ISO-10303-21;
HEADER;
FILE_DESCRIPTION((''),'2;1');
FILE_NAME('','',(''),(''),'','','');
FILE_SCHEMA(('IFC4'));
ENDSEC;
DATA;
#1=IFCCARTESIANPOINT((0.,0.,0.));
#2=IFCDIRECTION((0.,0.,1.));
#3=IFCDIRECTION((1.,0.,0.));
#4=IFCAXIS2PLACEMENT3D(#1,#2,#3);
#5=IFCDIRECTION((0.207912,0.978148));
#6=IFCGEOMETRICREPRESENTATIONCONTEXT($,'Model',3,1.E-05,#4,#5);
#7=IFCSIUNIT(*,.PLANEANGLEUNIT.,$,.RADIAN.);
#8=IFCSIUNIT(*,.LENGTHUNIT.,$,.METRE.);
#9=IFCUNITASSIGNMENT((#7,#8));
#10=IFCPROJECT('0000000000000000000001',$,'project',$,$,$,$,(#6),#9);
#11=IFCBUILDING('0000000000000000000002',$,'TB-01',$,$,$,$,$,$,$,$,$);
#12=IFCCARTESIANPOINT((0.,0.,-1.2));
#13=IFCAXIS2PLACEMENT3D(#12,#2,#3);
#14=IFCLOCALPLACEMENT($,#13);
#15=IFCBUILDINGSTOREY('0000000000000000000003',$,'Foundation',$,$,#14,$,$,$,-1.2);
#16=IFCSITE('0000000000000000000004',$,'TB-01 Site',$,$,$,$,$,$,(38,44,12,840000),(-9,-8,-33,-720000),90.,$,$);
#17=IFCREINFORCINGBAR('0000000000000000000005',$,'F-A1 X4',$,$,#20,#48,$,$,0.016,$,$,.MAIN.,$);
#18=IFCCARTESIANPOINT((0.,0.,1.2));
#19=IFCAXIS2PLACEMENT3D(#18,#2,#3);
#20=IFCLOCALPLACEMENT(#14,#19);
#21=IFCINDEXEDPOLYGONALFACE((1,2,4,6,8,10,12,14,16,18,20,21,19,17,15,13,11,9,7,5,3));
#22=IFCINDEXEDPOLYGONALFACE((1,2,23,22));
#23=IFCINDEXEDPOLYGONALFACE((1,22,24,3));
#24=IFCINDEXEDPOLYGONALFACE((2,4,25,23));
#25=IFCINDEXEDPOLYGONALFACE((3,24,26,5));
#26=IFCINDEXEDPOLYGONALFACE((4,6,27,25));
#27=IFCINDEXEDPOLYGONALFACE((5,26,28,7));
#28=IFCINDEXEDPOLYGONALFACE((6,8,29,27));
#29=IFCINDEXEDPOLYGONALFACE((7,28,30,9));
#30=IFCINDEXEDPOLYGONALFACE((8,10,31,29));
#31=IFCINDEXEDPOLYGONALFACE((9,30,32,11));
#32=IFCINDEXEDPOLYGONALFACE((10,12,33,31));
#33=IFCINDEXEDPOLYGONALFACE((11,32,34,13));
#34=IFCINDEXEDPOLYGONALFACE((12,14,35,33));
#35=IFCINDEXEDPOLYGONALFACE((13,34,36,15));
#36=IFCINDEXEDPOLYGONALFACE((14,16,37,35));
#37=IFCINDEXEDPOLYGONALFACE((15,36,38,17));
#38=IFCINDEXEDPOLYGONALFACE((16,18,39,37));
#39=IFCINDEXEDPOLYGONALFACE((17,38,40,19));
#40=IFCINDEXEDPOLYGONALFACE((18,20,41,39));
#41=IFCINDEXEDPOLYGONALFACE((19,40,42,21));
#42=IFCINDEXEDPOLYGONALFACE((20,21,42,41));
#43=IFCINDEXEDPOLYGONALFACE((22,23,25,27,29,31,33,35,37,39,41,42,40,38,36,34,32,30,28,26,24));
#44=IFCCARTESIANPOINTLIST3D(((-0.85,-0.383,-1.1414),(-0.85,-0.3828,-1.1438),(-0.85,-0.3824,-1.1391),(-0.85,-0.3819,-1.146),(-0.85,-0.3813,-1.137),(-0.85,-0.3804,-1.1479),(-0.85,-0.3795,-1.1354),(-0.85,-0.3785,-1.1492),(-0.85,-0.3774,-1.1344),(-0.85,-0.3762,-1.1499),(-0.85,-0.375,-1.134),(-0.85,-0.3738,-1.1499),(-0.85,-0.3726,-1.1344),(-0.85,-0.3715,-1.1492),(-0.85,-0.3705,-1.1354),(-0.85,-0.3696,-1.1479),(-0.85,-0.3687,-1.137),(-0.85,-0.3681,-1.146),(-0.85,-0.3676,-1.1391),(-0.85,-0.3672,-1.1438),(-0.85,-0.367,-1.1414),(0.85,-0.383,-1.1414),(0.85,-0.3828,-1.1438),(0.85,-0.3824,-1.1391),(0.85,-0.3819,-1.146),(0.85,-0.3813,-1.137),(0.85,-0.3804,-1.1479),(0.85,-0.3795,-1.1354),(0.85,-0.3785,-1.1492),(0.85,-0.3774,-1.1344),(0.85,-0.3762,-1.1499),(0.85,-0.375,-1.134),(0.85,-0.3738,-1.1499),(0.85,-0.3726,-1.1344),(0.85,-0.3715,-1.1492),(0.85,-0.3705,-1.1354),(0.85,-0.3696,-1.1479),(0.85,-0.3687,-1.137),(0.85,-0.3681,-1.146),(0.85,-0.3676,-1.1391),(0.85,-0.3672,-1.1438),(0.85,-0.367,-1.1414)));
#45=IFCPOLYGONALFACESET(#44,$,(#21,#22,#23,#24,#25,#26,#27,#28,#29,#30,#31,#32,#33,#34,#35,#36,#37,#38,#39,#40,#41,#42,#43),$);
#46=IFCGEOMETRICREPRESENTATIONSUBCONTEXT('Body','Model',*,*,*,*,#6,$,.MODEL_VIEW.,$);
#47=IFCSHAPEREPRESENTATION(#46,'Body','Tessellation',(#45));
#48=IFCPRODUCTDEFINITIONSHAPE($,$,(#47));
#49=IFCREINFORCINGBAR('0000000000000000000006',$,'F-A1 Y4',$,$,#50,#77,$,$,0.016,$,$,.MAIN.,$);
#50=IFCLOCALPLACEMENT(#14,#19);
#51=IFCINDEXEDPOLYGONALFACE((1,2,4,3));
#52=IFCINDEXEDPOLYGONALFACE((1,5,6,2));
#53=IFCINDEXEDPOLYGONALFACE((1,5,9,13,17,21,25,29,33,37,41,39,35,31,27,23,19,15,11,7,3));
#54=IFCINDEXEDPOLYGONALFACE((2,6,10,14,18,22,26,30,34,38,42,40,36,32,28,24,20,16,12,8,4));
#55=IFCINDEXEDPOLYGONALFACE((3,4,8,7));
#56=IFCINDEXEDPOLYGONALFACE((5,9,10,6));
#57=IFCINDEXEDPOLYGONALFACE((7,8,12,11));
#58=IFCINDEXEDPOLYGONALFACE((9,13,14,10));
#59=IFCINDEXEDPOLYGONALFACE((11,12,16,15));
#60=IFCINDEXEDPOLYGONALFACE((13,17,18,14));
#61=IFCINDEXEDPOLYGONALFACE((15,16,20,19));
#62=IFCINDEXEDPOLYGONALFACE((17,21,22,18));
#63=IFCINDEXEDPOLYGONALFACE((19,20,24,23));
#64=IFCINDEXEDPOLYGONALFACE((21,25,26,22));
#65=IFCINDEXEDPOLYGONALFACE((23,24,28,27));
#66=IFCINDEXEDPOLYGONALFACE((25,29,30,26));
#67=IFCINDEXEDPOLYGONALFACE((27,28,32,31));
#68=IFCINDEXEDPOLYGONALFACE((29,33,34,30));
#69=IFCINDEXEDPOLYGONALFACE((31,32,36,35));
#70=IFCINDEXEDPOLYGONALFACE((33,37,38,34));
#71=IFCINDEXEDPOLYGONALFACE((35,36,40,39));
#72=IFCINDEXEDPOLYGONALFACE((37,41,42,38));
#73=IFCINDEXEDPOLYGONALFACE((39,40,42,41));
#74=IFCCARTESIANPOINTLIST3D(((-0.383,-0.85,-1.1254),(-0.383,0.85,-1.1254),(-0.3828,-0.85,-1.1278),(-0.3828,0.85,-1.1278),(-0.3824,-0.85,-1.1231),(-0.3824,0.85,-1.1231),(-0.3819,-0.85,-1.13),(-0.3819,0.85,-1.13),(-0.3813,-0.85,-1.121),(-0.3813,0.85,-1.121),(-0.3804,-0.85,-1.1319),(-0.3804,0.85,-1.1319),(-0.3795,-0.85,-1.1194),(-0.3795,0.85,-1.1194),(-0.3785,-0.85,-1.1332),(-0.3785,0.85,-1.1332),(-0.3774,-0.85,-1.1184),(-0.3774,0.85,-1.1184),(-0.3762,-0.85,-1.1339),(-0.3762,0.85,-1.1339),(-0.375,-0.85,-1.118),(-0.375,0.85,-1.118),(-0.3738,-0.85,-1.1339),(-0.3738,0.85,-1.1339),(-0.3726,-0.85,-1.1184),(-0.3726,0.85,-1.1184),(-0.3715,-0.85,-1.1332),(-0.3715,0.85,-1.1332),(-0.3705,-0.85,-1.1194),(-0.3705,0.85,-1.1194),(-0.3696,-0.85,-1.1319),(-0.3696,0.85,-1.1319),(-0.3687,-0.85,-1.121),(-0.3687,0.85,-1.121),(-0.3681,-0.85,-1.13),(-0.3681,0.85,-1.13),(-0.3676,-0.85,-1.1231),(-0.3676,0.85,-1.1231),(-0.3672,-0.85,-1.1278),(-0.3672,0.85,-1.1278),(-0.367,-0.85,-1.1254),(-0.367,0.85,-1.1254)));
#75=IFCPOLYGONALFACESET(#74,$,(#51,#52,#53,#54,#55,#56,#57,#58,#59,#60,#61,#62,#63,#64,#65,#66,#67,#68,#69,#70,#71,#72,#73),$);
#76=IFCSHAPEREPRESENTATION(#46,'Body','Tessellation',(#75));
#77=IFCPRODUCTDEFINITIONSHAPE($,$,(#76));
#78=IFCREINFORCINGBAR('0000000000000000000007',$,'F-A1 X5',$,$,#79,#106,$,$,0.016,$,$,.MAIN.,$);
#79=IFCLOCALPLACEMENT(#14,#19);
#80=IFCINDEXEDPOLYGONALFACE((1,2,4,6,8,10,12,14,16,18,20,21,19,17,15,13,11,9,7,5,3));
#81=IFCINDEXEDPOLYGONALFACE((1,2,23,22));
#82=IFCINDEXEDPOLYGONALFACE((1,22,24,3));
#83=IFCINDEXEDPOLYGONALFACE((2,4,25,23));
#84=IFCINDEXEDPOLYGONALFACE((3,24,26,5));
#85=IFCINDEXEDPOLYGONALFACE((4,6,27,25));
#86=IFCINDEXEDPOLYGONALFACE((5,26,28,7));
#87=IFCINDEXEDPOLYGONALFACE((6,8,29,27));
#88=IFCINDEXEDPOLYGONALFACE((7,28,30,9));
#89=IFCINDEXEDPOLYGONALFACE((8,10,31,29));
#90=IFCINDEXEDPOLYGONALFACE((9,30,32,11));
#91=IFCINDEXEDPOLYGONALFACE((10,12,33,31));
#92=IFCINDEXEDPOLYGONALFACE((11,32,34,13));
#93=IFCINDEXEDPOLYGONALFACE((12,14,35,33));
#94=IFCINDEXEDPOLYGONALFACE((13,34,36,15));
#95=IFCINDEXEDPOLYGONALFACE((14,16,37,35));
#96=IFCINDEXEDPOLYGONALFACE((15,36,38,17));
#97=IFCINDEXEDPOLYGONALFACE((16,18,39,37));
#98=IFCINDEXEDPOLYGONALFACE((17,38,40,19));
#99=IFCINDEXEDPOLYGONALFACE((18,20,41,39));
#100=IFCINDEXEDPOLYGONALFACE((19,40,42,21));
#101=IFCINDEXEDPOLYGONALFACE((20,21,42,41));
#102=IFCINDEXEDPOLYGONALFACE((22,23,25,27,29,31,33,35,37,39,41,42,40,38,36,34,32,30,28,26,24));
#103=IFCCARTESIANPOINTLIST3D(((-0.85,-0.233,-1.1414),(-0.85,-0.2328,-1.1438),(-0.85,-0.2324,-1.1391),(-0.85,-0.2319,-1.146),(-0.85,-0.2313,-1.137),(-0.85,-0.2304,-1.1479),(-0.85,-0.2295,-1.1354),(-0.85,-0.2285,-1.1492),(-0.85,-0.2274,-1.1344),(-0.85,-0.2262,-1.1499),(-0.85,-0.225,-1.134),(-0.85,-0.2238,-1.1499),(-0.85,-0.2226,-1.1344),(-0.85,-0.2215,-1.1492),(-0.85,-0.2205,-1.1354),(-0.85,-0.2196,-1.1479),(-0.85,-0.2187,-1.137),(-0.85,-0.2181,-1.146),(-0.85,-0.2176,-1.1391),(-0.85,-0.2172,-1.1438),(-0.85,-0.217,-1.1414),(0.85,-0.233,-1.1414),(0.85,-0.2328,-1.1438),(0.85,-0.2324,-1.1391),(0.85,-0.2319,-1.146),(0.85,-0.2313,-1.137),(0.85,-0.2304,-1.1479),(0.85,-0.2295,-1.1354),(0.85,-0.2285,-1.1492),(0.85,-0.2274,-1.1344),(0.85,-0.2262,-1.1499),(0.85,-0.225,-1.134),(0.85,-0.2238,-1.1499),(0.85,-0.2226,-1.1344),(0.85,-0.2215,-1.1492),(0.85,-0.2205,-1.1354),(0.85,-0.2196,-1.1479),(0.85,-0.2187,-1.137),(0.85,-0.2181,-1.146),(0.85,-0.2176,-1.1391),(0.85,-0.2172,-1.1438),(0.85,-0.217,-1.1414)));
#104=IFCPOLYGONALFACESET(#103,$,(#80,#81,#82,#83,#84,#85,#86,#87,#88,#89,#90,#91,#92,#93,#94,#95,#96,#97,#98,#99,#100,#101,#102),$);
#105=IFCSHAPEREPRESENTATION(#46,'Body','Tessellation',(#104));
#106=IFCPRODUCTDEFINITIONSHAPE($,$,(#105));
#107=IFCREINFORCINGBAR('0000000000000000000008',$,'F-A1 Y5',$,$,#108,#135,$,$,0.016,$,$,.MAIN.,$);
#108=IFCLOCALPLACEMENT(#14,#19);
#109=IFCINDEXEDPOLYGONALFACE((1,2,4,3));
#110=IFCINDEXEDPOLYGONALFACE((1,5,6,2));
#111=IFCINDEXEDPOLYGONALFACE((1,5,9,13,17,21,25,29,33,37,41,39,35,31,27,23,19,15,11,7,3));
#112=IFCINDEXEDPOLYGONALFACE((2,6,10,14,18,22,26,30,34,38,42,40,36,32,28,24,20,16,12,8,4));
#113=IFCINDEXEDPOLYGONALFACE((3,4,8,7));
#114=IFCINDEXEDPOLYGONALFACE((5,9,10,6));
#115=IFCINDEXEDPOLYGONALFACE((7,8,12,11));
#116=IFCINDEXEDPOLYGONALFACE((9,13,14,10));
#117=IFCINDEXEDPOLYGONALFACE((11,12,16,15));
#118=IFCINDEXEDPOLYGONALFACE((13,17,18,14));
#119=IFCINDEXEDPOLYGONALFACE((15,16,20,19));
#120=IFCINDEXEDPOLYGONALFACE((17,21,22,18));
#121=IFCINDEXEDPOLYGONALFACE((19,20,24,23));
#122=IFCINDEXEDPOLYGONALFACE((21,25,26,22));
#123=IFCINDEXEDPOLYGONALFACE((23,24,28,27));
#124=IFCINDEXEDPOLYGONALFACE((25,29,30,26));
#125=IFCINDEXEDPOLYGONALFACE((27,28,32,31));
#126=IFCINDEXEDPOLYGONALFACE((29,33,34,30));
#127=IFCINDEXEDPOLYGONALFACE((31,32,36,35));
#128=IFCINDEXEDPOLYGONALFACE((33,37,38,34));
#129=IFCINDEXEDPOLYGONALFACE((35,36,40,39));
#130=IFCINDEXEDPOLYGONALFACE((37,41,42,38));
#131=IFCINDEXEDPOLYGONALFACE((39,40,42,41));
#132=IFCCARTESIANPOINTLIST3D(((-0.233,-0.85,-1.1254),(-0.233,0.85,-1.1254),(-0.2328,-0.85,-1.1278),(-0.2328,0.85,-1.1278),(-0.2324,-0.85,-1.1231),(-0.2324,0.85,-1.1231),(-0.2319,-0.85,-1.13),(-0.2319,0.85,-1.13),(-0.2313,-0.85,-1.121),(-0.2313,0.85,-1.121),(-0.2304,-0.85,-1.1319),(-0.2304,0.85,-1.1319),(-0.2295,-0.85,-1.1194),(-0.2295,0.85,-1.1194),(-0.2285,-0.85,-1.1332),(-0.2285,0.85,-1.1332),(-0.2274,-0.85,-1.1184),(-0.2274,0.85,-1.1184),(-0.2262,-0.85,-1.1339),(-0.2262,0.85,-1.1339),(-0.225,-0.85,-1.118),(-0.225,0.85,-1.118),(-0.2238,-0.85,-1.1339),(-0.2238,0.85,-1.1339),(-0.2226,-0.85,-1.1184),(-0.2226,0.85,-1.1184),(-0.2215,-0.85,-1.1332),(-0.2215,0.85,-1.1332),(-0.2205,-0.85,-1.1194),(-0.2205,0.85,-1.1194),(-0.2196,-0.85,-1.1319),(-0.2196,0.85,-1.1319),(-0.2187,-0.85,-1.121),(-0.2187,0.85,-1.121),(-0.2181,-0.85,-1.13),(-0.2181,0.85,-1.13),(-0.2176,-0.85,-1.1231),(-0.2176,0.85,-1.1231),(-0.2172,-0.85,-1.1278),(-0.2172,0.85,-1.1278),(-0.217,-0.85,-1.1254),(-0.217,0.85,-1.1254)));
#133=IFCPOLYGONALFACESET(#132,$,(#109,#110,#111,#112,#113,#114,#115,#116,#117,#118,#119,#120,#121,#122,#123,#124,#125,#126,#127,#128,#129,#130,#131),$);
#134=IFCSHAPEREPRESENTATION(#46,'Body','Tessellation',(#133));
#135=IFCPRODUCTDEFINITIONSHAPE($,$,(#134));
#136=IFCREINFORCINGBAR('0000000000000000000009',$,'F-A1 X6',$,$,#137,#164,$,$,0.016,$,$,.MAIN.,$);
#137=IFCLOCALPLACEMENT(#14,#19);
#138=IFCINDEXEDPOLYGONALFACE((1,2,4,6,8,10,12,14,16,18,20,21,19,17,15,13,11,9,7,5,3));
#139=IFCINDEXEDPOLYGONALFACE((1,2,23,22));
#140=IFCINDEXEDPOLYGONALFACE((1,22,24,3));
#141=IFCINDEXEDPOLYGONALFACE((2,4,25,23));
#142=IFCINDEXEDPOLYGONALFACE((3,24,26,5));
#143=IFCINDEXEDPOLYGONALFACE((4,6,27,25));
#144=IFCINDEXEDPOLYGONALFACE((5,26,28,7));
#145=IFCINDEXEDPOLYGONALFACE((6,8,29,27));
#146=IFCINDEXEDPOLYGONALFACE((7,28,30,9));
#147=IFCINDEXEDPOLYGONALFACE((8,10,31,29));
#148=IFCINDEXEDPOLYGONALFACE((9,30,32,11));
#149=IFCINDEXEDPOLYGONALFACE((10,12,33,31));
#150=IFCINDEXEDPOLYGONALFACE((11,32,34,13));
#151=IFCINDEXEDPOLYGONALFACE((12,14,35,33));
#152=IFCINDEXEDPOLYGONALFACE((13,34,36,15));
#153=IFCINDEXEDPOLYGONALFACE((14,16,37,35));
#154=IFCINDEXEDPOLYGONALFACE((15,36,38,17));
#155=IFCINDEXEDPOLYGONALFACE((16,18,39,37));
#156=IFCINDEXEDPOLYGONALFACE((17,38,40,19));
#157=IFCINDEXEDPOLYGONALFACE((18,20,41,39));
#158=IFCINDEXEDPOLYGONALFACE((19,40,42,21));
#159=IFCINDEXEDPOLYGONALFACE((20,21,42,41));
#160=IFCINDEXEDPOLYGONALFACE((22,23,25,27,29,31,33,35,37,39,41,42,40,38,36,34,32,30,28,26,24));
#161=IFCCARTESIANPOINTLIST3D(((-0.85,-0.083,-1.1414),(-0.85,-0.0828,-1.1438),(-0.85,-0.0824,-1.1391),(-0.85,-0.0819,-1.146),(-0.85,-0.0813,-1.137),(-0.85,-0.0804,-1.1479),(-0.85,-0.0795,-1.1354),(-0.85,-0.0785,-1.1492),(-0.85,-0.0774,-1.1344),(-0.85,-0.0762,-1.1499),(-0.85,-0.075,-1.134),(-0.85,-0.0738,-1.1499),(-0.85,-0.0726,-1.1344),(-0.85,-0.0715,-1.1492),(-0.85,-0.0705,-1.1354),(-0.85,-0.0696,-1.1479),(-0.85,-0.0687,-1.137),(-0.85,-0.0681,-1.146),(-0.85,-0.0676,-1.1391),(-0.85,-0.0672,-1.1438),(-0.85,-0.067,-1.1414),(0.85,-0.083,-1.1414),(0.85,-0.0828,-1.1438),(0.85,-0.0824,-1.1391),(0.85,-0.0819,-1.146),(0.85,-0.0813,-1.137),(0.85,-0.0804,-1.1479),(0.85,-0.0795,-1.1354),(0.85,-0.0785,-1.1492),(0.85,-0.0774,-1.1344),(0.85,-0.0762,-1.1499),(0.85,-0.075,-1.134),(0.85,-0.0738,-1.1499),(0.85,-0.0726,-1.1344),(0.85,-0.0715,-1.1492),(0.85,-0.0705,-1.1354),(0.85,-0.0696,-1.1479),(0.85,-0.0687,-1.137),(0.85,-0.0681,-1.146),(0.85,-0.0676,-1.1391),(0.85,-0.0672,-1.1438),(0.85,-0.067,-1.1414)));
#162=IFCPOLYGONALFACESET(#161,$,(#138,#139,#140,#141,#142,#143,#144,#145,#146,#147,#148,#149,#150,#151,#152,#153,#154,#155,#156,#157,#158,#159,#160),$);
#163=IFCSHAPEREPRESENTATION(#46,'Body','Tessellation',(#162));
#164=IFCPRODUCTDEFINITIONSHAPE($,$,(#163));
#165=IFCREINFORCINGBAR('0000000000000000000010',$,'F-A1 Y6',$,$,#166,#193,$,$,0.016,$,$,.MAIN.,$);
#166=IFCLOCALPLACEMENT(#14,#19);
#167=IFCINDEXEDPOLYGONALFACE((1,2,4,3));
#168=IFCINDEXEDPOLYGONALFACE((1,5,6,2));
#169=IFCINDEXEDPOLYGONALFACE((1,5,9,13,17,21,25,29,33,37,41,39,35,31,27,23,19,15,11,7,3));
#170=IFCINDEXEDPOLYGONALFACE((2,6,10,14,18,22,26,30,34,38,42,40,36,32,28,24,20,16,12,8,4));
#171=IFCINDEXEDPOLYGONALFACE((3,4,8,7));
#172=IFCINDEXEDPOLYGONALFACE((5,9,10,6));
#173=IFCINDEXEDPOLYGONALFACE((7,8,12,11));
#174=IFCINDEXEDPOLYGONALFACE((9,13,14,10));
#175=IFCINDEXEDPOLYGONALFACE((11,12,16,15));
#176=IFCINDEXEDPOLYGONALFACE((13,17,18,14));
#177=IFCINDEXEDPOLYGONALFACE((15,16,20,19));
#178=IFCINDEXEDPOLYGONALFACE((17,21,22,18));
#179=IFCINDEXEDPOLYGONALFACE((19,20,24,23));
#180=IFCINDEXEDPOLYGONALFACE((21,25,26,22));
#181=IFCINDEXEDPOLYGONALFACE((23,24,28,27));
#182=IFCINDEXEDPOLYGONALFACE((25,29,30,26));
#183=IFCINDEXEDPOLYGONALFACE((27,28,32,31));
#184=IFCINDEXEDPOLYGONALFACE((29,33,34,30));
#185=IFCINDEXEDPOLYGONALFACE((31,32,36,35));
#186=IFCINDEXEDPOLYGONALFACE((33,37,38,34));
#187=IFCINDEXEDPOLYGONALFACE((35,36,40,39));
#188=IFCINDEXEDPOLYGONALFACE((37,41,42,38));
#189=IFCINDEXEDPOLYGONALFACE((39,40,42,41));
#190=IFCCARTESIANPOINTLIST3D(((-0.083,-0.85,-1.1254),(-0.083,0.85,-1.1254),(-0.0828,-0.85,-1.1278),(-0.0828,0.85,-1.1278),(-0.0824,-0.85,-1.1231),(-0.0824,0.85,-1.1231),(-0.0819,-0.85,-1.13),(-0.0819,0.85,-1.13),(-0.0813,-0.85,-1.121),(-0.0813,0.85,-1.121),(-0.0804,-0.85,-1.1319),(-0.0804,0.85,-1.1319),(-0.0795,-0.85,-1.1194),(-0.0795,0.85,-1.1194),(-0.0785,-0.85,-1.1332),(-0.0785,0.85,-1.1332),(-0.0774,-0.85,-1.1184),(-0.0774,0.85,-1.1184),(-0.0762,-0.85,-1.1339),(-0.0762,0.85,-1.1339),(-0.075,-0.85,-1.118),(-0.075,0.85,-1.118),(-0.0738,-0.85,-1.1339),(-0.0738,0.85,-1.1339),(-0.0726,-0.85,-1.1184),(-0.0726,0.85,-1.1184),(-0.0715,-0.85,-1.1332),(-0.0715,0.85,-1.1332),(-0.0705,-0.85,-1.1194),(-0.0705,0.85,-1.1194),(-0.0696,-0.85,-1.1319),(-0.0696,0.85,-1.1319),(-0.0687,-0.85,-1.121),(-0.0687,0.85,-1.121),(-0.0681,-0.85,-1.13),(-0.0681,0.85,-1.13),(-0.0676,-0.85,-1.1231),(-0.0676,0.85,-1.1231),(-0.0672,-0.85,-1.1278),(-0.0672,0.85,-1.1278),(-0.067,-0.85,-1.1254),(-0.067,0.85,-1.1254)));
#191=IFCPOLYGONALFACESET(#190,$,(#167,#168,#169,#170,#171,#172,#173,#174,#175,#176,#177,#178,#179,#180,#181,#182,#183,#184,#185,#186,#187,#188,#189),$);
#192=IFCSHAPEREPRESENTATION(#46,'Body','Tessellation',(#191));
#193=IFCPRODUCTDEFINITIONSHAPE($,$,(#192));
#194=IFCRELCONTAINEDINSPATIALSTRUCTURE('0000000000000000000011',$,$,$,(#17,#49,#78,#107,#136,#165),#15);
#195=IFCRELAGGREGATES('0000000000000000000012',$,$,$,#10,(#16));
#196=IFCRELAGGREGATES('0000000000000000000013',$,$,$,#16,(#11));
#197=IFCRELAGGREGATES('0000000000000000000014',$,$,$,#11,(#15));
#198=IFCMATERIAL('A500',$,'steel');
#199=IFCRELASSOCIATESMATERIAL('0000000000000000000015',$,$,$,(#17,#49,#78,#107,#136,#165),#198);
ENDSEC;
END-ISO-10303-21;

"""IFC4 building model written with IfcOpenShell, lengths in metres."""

from ifc_helpers import new_model, entity, si_unit, direction, frame, origin_with_axes, place, context, subcontext, project, spatial, material, element, save


model = new_model("IFC4")

# Units and contexts
model_context = context("Model", 3, precision=1e-05, world=origin_with_axes(), true_north=direction((0.207912, 0.978148)))
body_context = subcontext(model_context, "Body", "Model", "MODEL_VIEW")
ifc_project = project(units=[si_unit("PLANEANGLEUNIT", "RADIAN"), si_unit("LENGTHUNIT", "METRE")], contexts=[model_context])

# Site, building, storey
site = spatial("IfcSite", under=ifc_project, Name="TB-01 Site", RefLatitude=(38, 44, 12, 840000), RefLongitude=(-9, -8, -33, -720000), RefElevation=90.0)
building = spatial("IfcBuilding", under=site, Name="TB-01")
storey_placement = place(None, frame((0.0, 0.0, -1.2), z_axis=(0.0, 0.0, 1.0), x_axis=(1.0, 0.0, 0.0)))
storey = spatial("IfcBuildingStorey", under=building, at=storey_placement, Name="Foundation", Elevation=-1.2)

# Reinforcing bars
ifc_material_1 = material(Name="A500", Category="steel")
reinforcing_bar_1_placement = place(storey_placement, frame((0.0, 0.0, 1.2), z_axis=(0.0, 0.0, 1.0), x_axis=(1.0, 0.0, 0.0)))
element("IfcReinforcingBar", 1, at=reinforcing_bar_1_placement, inside=storey, material=ifc_material_1, Name="F-A1 X4", NominalDiameter=0.016, PredefinedType="MAIN", context=body_context, shape_type="AdvancedSweptSolid", body=[
    entity("IfcSweptDiskSolid", entity("IfcPolyline", [entity("IfcCartesianPoint", [-0.85, -0.375, -1.142]), entity("IfcCartesianPoint", [0.85, -0.375, -1.142])]), 0.008),
])
reinforcing_bar_2_placement = place(storey_placement, frame((0.0, 0.0, 1.2), z_axis=(0.0, 0.0, 1.0), x_axis=(1.0, 0.0, 0.0)))
element("IfcReinforcingBar", 2, at=reinforcing_bar_2_placement, inside=storey, material=ifc_material_1, Name="F-A1 Y4", NominalDiameter=0.016, PredefinedType="MAIN", context=body_context, shape_type="AdvancedSweptSolid", body=[
    entity("IfcSweptDiskSolid", entity("IfcPolyline", [entity("IfcCartesianPoint", [-0.375, -0.85, -1.126]), entity("IfcCartesianPoint", [-0.375, 0.85, -1.126])]), 0.008),
])
reinforcing_bar_3_placement = place(storey_placement, frame((0.0, 0.0, 1.2), z_axis=(0.0, 0.0, 1.0), x_axis=(1.0, 0.0, 0.0)))
element("IfcReinforcingBar", 3, at=reinforcing_bar_3_placement, inside=storey, material=ifc_material_1, Name="F-A1 X5", NominalDiameter=0.016, PredefinedType="MAIN", context=body_context, shape_type="AdvancedSweptSolid", body=[
    entity("IfcSweptDiskSolid", entity("IfcPolyline", [entity("IfcCartesianPoint", [-0.85, -0.225, -1.142]), entity("IfcCartesianPoint", [0.85, -0.225, -1.142])]), 0.008),
])
reinforcing_bar_4_placement = place(storey_placement, frame((0.0, 0.0, 1.2), z_axis=(0.0, 0.0, 1.0), x_axis=(1.0, 0.0, 0.0)))
element("IfcReinforcingBar", 4, at=reinforcing_bar_4_placement, inside=storey, material=ifc_material_1, Name="F-A1 Y5", NominalDiameter=0.016, PredefinedType="MAIN", context=body_context, shape_type="AdvancedSweptSolid", body=[
    entity("IfcSweptDiskSolid", entity("IfcPolyline", [entity("IfcCartesianPoint", [-0.225, -0.85, -1.126]), entity("IfcCartesianPoint", [-0.225, 0.85, -1.126])]), 0.008),
])
reinforcing_bar_5_placement = place(storey_placement, frame((0.0, 0.0, 1.2), z_axis=(0.0, 0.0, 1.0), x_axis=(1.0, 0.0, 0.0)))
element("IfcReinforcingBar", 5, at=reinforcing_bar_5_placement, inside=storey, material=ifc_material_1, Name="F-A1 X6", NominalDiameter=0.016, PredefinedType="MAIN", context=body_context, shape_type="AdvancedSweptSolid", body=[
    entity("IfcSweptDiskSolid", entity("IfcPolyline", [entity("IfcCartesianPoint", [-0.85, -0.075, -1.142]), entity("IfcCartesianPoint", [0.85, -0.075, -1.142])]), 0.008),
])
reinforcing_bar_6_placement = place(storey_placement, frame((0.0, 0.0, 1.2), z_axis=(0.0, 0.0, 1.0), x_axis=(1.0, 0.0, 0.0)))
element("IfcReinforcingBar", 6, at=reinforcing_bar_6_placement, inside=storey, material=ifc_material_1, Name="F-A1 Y6", NominalDiameter=0.016, PredefinedType="MAIN", context=body_context, shape_type="AdvancedSweptSolid", body=[
    entity("IfcSweptDiskSolid", entity("IfcPolyline", [entity("IfcCartesianPoint", [-0.075, -0.85, -1.126]), entity("IfcCartesianPoint", [-0.075, 0.85, -1.126])]), 0.008),
])

save(model, "model.ifc")
